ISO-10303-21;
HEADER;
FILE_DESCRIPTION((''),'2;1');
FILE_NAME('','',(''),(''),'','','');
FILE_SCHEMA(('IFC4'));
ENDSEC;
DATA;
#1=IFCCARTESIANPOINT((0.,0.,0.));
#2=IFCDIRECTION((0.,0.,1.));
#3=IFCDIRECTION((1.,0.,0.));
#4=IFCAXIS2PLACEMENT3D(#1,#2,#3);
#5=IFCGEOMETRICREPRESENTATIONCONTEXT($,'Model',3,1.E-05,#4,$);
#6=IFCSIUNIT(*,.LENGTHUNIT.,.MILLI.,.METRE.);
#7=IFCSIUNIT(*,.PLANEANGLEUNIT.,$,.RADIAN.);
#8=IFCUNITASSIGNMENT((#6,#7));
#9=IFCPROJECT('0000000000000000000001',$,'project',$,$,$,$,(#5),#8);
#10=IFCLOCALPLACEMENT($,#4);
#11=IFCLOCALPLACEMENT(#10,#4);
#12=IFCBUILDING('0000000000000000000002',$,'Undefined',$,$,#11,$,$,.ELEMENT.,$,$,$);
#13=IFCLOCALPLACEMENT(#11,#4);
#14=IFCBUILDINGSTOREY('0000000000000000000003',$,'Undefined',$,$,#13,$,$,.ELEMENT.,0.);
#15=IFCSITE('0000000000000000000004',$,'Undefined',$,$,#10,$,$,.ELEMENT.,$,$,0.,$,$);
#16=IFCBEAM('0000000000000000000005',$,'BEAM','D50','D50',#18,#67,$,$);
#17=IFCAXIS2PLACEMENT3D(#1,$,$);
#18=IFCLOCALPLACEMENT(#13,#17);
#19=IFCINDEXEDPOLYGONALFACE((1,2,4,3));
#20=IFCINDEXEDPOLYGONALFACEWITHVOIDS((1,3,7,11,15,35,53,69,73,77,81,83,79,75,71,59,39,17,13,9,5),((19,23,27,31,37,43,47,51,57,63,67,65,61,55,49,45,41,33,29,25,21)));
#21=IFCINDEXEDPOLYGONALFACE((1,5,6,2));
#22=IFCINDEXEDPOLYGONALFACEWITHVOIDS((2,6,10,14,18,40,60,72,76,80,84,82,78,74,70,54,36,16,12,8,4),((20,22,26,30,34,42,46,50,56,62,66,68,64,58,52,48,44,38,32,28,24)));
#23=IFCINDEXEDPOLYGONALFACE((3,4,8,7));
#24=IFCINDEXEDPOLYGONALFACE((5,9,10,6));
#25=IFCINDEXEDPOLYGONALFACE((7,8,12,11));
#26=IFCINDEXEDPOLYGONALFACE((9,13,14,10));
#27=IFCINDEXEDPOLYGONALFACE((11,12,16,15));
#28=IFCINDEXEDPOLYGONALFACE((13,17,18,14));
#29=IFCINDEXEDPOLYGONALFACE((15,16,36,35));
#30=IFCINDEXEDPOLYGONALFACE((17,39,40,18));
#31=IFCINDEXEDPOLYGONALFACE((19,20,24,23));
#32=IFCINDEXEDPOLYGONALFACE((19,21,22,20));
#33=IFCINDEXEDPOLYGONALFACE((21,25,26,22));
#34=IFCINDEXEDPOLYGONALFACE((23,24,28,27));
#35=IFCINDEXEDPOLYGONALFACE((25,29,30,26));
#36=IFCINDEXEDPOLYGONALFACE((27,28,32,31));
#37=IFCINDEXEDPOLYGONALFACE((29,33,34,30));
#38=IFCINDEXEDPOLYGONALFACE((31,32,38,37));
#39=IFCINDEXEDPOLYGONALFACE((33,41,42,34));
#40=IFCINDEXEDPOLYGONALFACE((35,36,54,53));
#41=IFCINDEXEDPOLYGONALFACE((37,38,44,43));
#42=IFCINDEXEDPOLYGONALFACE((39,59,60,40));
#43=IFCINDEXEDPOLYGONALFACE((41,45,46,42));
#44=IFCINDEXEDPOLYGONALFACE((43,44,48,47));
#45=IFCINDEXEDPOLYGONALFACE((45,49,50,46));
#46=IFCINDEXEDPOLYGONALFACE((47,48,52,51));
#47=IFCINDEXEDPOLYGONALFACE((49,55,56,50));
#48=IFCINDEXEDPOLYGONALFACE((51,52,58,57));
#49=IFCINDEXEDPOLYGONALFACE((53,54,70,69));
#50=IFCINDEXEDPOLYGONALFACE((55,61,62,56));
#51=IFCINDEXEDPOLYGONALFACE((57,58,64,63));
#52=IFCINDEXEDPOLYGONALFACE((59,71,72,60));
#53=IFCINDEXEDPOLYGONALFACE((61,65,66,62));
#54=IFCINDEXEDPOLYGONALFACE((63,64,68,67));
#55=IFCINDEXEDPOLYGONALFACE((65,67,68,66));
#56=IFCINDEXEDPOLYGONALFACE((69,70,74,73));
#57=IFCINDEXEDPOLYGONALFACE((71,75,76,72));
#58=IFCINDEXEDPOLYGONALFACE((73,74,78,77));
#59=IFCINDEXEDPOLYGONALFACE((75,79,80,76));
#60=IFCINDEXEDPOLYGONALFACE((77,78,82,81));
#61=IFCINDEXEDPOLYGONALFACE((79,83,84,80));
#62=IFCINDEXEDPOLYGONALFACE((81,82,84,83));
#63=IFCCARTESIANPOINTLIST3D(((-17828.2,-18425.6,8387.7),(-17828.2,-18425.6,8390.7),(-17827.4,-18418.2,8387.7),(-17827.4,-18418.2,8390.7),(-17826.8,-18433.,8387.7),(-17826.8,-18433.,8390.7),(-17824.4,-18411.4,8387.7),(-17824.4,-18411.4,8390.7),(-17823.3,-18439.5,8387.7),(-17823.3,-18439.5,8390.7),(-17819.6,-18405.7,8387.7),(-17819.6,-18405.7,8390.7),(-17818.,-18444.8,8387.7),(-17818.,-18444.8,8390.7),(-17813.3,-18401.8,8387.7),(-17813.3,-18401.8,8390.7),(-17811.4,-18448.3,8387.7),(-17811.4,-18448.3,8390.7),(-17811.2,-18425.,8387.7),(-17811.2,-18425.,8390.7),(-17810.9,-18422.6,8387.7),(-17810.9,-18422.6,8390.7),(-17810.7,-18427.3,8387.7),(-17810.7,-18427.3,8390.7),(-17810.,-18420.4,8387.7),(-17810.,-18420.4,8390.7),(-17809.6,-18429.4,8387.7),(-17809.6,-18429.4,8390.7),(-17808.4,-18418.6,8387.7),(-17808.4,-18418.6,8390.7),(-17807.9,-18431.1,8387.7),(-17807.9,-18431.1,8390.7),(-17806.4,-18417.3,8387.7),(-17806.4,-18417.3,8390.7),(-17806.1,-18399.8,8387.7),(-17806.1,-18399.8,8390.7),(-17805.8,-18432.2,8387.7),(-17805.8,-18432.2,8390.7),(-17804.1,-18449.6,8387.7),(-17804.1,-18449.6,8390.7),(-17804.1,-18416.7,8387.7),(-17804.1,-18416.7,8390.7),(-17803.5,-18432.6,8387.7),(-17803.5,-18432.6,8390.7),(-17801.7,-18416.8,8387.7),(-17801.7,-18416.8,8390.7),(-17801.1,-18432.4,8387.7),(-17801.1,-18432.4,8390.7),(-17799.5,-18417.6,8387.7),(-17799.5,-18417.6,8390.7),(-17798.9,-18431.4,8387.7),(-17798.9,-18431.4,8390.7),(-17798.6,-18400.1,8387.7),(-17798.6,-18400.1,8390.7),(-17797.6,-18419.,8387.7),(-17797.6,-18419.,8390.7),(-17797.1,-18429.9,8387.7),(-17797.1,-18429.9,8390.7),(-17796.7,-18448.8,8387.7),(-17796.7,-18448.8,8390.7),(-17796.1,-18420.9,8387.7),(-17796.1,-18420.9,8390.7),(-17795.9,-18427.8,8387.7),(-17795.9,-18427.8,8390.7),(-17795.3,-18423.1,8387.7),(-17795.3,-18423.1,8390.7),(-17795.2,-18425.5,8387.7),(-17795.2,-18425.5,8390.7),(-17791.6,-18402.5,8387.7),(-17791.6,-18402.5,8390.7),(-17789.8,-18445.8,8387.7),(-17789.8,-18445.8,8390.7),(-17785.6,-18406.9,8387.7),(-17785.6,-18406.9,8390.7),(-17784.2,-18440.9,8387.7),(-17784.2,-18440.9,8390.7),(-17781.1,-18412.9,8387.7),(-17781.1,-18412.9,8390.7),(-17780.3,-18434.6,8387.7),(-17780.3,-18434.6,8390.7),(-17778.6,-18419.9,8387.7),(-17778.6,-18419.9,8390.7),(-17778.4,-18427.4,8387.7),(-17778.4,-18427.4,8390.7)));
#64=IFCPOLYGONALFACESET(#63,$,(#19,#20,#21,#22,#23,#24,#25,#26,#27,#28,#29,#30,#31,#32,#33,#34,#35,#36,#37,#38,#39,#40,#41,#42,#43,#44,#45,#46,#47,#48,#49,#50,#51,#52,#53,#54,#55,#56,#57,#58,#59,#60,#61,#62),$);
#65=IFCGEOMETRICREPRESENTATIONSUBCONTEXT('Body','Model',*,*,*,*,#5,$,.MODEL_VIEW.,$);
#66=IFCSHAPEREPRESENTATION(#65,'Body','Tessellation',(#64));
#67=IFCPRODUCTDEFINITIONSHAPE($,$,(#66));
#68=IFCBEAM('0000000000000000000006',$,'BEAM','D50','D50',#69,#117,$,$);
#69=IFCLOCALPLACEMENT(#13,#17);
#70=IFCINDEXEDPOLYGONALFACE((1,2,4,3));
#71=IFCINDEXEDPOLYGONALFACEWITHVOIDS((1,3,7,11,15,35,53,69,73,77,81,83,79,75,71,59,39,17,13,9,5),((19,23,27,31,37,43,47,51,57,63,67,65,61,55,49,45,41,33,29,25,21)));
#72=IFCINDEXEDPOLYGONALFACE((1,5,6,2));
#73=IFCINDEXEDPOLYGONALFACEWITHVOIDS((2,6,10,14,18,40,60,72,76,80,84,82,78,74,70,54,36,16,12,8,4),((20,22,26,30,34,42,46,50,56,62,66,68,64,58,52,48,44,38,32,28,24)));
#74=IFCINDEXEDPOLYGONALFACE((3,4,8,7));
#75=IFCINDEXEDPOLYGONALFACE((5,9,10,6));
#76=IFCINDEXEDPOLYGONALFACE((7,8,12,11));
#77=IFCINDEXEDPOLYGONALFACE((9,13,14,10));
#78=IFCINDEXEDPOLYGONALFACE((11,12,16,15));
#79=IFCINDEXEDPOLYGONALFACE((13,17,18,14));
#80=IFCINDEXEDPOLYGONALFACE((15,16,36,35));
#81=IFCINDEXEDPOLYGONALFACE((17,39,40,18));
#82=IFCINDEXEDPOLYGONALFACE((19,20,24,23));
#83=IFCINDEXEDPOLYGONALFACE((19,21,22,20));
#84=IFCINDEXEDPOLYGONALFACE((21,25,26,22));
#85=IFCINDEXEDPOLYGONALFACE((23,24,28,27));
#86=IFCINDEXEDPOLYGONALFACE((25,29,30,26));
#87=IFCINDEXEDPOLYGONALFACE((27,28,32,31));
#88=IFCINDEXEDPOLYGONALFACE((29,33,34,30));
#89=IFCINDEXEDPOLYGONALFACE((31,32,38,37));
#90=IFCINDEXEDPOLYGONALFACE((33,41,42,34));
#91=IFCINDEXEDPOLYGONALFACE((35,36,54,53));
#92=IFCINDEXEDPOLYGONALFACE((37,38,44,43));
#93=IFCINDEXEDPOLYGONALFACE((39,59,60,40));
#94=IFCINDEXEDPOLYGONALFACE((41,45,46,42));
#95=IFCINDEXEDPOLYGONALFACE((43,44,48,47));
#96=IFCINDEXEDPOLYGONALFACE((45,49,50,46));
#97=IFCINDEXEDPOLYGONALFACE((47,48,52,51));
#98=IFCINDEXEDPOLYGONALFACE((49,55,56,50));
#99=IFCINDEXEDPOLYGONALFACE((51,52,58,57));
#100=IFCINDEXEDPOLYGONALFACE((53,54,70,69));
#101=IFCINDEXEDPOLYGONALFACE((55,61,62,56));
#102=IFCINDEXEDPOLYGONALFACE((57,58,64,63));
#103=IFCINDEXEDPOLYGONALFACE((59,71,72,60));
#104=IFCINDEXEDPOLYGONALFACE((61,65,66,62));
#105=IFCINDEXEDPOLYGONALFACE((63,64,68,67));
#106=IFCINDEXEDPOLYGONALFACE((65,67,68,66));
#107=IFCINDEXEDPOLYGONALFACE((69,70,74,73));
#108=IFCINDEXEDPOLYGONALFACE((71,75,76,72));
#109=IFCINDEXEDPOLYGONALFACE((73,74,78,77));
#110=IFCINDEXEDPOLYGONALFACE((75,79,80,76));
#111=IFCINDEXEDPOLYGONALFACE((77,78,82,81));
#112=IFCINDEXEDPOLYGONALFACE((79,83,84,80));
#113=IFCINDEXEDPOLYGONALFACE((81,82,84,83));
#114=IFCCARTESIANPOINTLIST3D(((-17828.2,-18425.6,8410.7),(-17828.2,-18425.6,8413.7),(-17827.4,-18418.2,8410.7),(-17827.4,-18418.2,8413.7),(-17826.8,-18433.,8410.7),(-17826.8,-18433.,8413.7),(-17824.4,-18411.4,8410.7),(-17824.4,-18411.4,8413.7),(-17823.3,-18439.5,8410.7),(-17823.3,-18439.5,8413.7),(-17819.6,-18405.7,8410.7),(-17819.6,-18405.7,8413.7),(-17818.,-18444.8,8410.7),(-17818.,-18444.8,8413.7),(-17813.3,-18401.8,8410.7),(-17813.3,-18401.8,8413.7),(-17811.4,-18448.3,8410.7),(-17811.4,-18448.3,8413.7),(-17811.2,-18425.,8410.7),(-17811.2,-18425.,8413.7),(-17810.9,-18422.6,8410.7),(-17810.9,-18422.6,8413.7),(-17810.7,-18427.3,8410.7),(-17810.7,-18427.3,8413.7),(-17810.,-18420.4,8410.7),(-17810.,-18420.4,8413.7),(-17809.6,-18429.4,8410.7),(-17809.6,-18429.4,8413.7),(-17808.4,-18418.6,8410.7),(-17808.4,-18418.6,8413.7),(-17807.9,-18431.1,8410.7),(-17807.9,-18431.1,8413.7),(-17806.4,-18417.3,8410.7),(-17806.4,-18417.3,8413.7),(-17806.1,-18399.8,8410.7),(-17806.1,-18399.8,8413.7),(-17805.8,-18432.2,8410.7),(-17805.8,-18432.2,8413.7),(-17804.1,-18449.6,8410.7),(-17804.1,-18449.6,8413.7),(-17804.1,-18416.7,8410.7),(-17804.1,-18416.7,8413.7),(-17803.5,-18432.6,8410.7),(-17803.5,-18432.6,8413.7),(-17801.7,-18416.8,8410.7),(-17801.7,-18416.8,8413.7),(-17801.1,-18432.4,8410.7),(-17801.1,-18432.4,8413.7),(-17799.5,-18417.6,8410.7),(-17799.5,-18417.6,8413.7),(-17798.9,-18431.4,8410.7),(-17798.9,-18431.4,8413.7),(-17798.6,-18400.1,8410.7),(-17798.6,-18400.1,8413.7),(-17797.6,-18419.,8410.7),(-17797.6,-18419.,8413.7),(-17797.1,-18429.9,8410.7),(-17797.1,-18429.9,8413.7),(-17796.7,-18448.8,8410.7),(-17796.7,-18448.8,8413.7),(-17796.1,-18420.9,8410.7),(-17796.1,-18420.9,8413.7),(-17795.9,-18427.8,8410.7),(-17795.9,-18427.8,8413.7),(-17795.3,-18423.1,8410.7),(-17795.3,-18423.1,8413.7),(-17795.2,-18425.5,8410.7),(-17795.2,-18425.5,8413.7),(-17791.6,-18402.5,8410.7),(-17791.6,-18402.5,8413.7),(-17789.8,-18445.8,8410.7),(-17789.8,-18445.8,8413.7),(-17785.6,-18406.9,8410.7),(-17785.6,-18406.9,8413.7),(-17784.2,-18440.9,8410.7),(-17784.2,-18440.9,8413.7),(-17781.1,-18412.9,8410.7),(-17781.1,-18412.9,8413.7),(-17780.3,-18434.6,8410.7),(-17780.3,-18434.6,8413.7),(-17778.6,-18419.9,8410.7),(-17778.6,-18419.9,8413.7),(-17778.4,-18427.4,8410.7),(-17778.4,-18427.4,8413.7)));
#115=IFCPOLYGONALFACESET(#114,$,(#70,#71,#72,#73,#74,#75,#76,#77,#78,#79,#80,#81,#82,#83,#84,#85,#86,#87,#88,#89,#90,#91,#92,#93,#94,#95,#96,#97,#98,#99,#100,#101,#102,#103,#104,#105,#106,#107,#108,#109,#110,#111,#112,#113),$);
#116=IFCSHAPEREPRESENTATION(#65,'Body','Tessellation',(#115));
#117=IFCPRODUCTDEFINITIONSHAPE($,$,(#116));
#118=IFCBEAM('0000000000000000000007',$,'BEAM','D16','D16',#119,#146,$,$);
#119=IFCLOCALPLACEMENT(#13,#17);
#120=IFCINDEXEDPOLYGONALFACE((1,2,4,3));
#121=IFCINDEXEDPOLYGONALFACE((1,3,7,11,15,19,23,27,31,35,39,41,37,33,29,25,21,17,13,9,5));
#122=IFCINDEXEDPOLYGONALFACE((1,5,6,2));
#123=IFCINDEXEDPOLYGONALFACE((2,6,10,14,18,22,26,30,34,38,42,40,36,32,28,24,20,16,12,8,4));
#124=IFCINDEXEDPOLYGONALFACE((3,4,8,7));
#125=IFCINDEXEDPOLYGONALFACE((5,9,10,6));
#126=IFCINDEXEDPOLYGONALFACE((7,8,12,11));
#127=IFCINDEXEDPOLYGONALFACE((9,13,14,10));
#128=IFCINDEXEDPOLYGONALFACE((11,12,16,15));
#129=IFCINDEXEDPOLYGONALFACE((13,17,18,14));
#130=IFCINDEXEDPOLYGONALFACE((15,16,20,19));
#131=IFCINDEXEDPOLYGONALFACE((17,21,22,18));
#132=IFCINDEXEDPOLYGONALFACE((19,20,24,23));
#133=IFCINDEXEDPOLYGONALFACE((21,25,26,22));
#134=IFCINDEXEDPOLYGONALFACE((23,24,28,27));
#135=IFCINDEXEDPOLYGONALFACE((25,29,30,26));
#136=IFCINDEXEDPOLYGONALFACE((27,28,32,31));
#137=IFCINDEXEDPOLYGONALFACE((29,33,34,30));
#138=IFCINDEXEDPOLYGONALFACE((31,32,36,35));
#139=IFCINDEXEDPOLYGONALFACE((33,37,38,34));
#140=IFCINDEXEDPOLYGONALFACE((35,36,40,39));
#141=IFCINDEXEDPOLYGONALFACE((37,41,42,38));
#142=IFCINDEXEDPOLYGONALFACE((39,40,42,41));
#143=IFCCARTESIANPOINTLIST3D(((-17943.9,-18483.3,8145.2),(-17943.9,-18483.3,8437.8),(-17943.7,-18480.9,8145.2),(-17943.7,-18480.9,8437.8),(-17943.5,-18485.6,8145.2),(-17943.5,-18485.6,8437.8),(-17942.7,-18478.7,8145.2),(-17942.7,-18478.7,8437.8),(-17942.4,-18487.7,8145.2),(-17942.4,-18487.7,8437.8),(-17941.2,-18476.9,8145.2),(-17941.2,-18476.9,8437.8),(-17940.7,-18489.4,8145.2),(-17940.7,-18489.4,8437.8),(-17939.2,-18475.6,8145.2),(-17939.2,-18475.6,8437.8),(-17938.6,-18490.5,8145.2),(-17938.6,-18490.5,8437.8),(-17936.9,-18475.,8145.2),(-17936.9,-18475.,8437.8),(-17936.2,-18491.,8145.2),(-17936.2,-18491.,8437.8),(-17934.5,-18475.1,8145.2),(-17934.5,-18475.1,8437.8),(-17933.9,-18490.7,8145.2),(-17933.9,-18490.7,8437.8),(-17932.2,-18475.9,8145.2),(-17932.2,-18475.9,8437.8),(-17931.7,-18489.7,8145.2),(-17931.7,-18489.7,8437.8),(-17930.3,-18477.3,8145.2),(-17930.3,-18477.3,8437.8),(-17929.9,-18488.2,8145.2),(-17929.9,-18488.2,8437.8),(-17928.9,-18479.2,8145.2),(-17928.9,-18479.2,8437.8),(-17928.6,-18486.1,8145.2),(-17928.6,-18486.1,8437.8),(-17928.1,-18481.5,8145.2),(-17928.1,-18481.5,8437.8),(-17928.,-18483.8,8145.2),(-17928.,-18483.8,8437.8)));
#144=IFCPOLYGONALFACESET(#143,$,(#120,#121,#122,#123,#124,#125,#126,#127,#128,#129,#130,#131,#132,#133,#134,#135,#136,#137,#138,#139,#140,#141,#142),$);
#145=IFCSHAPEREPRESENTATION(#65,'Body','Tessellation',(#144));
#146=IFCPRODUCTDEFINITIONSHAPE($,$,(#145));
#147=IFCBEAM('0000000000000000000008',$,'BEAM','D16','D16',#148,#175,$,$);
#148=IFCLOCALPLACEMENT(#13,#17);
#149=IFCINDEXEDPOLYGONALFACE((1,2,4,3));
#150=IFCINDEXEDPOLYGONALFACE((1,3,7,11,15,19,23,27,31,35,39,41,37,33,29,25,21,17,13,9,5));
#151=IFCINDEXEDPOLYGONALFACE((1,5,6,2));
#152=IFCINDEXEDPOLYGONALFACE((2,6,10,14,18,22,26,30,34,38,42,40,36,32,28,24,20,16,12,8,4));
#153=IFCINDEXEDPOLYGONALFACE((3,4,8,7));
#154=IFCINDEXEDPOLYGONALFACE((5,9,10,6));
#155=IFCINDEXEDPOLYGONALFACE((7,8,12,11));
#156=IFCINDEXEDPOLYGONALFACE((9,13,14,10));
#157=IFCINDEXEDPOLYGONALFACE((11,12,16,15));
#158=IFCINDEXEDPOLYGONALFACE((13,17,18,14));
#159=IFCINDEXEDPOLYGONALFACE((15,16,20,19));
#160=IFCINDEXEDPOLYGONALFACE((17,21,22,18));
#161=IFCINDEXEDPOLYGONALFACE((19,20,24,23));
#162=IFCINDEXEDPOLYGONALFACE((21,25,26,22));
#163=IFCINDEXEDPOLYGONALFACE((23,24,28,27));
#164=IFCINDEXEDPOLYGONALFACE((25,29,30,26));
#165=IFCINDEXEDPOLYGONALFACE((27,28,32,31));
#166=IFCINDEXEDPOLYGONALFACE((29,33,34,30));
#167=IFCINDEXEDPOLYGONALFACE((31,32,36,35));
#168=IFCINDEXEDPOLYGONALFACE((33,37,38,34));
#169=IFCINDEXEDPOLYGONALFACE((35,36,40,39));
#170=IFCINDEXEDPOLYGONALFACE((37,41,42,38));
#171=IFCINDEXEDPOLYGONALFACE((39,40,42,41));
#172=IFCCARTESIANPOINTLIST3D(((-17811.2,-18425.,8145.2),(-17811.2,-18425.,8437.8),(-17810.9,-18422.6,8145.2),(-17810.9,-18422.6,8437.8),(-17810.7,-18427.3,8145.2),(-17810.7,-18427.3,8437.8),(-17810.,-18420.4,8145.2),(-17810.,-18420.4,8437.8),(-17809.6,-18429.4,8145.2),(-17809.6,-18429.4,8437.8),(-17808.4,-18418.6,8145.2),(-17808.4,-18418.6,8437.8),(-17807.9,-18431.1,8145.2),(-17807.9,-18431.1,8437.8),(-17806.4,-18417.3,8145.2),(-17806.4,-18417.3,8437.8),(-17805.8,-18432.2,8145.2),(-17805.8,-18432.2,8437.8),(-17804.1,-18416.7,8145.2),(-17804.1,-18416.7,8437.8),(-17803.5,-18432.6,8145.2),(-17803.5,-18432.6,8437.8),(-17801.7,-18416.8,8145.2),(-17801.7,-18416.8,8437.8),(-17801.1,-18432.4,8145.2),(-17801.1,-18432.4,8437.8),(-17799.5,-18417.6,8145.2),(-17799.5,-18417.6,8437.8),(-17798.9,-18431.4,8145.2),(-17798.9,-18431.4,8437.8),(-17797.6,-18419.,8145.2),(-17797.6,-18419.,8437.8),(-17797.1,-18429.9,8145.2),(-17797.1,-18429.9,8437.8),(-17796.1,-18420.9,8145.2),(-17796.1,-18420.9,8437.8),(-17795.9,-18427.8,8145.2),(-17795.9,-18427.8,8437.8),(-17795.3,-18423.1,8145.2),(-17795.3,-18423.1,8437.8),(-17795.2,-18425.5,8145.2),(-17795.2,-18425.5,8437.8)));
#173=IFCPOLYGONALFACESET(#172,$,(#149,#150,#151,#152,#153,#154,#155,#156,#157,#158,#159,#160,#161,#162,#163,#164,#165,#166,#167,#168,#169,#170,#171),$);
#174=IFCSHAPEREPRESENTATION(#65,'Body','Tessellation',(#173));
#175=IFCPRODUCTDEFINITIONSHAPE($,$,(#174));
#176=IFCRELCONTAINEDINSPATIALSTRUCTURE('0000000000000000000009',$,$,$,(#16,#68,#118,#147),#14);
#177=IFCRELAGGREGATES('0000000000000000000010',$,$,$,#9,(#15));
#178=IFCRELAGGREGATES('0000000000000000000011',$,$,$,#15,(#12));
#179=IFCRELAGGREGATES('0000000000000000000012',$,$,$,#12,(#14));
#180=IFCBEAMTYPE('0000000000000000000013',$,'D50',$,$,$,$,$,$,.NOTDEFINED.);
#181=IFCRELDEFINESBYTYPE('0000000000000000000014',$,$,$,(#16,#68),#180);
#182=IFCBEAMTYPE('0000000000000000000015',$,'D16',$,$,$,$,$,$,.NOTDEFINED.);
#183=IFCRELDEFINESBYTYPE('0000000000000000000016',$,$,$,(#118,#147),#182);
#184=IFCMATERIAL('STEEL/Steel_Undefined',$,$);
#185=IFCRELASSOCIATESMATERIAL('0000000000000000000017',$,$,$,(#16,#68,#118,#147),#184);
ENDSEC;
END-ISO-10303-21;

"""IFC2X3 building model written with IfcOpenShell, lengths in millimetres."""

from ifc_helpers import new_model, si_unit, frame, origin_with_axes, origin_2d_with_axis, place, context, subcontext, project, spatial, circle, extrude, material, type_object, element, save


model = new_model("IFC2X3")

# Units and contexts
model_context = context("Model", 3, precision=1e-05, world=origin_with_axes())
body_context = subcontext(model_context, "Body", "Model", "MODEL_VIEW")
ifc_project = project(units=[si_unit("LENGTHUNIT", "METRE", prefix="MILLI"), si_unit("PLANEANGLEUNIT", "RADIAN")], contexts=[model_context])

# Site, building, storey
site_placement = place(None, origin_with_axes())
site = spatial("IfcSite", under=ifc_project, at=site_placement, Name="Undefined", CompositionType="ELEMENT", RefElevation=0.0)
building_placement = place(site_placement, origin_with_axes())
building = spatial("IfcBuilding", under=site, at=building_placement, Name="Undefined", CompositionType="ELEMENT")
storey_placement = place(building_placement, origin_with_axes())
storey = spatial("IfcBuildingStorey", under=building, at=storey_placement, Name="Undefined", CompositionType="ELEMENT", Elevation=0.0)

# Shared definitions
ifc_material_1 = material(Name="STEEL/Steel_Undefined")

# Beams, openings
beam_type_1 = type_object("IfcBeamType", Name="D50", PredefinedType="NOTDEFINED")
beam_1_placement = place(storey_placement, frame((-17803.2, -18424.6, 8390.7), z_axis=(-0.915553, -0.402198, 0.0), x_axis=(0.0, 0.0, -1.0)))
beam_1 = element("IfcBeam", 1, at=beam_1_placement, inside=storey, type_object=beam_type_1, material=ifc_material_1, Name="BEAM", Description="D50", ObjectType="D50", context=body_context, shape_type="SweptSolid", body=[
    extrude(circle(Radius=25.0, at=origin_2d_with_axis()), frame((3.0, 0.0, 0.0), z_axis=(-1.0, 0.0, 0.0), x_axis=(0.0, -1.0, 0.0)), (0.0, 0.0, 1.0), 3.0),
])
opening_1_placement = place(storey_placement, frame((-17803.2, -18424.6, 8390.7), z_axis=(-0.915553, -0.402198, 0.0), x_axis=(0.0, 0.0, -1.0)))
element("IfcOpeningElement", 2, at=opening_1_placement, cuts=beam_1, ObjectType="Recess", context=body_context, shape_type="SweptSolid", body=[
    extrude(circle(Radius=8.0, at=origin_2d_with_axis()), frame((245.5, 0.0, 0.0), z_axis=(-1.0, 0.0, 0.0), x_axis=(0.0, -1.0, 0.0)), (0.0, 0.0, 1.0), 292.6),
])
beam_2_placement = place(storey_placement, frame((-17803.2, -18424.6, 8413.7), z_axis=(-0.915553, -0.402198, 0.0), x_axis=(0.0, 0.0, -1.0)))
beam_2 = element("IfcBeam", 3, at=beam_2_placement, inside=storey, type_object=beam_type_1, material=ifc_material_1, Name="BEAM", Description="D50", ObjectType="D50", context=body_context, shape_type="SweptSolid", body=[
    extrude(circle(Radius=25.0, at=origin_2d_with_axis()), frame((3.0, 0.0, 0.0), z_axis=(-1.0, 0.0, 0.0), x_axis=(0.0, -1.0, 0.0)), (0.0, 0.0, 1.0), 3.0),
])
opening_2_placement = place(storey_placement, frame((-17803.2, -18424.6, 8413.7), z_axis=(-0.915553, -0.402198, 0.0), x_axis=(0.0, 0.0, -1.0)))
element("IfcOpeningElement", 4, at=opening_2_placement, cuts=beam_2, ObjectType="Recess", context=body_context, shape_type="SweptSolid", body=[
    extrude(circle(Radius=8.0, at=origin_2d_with_axis()), frame((268.5, 0.0, 0.0), z_axis=(-1.0, 0.0, 0.0), x_axis=(0.0, -1.0, 0.0)), (0.0, 0.0, 1.0), 292.6),
])

# Beams
beam_type_2 = type_object("IfcBeamType", Name="D16", PredefinedType="NOTDEFINED")
for number, where, z_axis, x_axis, name in (
    (5, (-17936.0, -18483.0, 8437.8), (-0.915553, -0.402198, 0.0), (0.0, 0.0, -1.0), "BEAM"),
    (6, (-17803.2, -18424.6, 8437.8), (-0.915553, -0.402198, 0.0), (0.0, 0.0, -1.0), "BEAM"),
):
    element("IfcBeam", number, at=place(storey_placement, frame(where, z_axis=z_axis, x_axis=x_axis)), inside=storey, type_object=beam_type_2, material=ifc_material_1, Name=name, Description="D16", ObjectType="D16", context=body_context, shape_type="SweptSolid", body=[
        extrude(circle(Radius=8.0, at=origin_2d_with_axis()), frame((292.6, 0.0, 0.0), z_axis=(-1.0, 0.0, 0.0), x_axis=(0.0, -1.0, 0.0)), (0.0, 0.0, 1.0), 292.6),
    ])

save(model, "model.ifc")
